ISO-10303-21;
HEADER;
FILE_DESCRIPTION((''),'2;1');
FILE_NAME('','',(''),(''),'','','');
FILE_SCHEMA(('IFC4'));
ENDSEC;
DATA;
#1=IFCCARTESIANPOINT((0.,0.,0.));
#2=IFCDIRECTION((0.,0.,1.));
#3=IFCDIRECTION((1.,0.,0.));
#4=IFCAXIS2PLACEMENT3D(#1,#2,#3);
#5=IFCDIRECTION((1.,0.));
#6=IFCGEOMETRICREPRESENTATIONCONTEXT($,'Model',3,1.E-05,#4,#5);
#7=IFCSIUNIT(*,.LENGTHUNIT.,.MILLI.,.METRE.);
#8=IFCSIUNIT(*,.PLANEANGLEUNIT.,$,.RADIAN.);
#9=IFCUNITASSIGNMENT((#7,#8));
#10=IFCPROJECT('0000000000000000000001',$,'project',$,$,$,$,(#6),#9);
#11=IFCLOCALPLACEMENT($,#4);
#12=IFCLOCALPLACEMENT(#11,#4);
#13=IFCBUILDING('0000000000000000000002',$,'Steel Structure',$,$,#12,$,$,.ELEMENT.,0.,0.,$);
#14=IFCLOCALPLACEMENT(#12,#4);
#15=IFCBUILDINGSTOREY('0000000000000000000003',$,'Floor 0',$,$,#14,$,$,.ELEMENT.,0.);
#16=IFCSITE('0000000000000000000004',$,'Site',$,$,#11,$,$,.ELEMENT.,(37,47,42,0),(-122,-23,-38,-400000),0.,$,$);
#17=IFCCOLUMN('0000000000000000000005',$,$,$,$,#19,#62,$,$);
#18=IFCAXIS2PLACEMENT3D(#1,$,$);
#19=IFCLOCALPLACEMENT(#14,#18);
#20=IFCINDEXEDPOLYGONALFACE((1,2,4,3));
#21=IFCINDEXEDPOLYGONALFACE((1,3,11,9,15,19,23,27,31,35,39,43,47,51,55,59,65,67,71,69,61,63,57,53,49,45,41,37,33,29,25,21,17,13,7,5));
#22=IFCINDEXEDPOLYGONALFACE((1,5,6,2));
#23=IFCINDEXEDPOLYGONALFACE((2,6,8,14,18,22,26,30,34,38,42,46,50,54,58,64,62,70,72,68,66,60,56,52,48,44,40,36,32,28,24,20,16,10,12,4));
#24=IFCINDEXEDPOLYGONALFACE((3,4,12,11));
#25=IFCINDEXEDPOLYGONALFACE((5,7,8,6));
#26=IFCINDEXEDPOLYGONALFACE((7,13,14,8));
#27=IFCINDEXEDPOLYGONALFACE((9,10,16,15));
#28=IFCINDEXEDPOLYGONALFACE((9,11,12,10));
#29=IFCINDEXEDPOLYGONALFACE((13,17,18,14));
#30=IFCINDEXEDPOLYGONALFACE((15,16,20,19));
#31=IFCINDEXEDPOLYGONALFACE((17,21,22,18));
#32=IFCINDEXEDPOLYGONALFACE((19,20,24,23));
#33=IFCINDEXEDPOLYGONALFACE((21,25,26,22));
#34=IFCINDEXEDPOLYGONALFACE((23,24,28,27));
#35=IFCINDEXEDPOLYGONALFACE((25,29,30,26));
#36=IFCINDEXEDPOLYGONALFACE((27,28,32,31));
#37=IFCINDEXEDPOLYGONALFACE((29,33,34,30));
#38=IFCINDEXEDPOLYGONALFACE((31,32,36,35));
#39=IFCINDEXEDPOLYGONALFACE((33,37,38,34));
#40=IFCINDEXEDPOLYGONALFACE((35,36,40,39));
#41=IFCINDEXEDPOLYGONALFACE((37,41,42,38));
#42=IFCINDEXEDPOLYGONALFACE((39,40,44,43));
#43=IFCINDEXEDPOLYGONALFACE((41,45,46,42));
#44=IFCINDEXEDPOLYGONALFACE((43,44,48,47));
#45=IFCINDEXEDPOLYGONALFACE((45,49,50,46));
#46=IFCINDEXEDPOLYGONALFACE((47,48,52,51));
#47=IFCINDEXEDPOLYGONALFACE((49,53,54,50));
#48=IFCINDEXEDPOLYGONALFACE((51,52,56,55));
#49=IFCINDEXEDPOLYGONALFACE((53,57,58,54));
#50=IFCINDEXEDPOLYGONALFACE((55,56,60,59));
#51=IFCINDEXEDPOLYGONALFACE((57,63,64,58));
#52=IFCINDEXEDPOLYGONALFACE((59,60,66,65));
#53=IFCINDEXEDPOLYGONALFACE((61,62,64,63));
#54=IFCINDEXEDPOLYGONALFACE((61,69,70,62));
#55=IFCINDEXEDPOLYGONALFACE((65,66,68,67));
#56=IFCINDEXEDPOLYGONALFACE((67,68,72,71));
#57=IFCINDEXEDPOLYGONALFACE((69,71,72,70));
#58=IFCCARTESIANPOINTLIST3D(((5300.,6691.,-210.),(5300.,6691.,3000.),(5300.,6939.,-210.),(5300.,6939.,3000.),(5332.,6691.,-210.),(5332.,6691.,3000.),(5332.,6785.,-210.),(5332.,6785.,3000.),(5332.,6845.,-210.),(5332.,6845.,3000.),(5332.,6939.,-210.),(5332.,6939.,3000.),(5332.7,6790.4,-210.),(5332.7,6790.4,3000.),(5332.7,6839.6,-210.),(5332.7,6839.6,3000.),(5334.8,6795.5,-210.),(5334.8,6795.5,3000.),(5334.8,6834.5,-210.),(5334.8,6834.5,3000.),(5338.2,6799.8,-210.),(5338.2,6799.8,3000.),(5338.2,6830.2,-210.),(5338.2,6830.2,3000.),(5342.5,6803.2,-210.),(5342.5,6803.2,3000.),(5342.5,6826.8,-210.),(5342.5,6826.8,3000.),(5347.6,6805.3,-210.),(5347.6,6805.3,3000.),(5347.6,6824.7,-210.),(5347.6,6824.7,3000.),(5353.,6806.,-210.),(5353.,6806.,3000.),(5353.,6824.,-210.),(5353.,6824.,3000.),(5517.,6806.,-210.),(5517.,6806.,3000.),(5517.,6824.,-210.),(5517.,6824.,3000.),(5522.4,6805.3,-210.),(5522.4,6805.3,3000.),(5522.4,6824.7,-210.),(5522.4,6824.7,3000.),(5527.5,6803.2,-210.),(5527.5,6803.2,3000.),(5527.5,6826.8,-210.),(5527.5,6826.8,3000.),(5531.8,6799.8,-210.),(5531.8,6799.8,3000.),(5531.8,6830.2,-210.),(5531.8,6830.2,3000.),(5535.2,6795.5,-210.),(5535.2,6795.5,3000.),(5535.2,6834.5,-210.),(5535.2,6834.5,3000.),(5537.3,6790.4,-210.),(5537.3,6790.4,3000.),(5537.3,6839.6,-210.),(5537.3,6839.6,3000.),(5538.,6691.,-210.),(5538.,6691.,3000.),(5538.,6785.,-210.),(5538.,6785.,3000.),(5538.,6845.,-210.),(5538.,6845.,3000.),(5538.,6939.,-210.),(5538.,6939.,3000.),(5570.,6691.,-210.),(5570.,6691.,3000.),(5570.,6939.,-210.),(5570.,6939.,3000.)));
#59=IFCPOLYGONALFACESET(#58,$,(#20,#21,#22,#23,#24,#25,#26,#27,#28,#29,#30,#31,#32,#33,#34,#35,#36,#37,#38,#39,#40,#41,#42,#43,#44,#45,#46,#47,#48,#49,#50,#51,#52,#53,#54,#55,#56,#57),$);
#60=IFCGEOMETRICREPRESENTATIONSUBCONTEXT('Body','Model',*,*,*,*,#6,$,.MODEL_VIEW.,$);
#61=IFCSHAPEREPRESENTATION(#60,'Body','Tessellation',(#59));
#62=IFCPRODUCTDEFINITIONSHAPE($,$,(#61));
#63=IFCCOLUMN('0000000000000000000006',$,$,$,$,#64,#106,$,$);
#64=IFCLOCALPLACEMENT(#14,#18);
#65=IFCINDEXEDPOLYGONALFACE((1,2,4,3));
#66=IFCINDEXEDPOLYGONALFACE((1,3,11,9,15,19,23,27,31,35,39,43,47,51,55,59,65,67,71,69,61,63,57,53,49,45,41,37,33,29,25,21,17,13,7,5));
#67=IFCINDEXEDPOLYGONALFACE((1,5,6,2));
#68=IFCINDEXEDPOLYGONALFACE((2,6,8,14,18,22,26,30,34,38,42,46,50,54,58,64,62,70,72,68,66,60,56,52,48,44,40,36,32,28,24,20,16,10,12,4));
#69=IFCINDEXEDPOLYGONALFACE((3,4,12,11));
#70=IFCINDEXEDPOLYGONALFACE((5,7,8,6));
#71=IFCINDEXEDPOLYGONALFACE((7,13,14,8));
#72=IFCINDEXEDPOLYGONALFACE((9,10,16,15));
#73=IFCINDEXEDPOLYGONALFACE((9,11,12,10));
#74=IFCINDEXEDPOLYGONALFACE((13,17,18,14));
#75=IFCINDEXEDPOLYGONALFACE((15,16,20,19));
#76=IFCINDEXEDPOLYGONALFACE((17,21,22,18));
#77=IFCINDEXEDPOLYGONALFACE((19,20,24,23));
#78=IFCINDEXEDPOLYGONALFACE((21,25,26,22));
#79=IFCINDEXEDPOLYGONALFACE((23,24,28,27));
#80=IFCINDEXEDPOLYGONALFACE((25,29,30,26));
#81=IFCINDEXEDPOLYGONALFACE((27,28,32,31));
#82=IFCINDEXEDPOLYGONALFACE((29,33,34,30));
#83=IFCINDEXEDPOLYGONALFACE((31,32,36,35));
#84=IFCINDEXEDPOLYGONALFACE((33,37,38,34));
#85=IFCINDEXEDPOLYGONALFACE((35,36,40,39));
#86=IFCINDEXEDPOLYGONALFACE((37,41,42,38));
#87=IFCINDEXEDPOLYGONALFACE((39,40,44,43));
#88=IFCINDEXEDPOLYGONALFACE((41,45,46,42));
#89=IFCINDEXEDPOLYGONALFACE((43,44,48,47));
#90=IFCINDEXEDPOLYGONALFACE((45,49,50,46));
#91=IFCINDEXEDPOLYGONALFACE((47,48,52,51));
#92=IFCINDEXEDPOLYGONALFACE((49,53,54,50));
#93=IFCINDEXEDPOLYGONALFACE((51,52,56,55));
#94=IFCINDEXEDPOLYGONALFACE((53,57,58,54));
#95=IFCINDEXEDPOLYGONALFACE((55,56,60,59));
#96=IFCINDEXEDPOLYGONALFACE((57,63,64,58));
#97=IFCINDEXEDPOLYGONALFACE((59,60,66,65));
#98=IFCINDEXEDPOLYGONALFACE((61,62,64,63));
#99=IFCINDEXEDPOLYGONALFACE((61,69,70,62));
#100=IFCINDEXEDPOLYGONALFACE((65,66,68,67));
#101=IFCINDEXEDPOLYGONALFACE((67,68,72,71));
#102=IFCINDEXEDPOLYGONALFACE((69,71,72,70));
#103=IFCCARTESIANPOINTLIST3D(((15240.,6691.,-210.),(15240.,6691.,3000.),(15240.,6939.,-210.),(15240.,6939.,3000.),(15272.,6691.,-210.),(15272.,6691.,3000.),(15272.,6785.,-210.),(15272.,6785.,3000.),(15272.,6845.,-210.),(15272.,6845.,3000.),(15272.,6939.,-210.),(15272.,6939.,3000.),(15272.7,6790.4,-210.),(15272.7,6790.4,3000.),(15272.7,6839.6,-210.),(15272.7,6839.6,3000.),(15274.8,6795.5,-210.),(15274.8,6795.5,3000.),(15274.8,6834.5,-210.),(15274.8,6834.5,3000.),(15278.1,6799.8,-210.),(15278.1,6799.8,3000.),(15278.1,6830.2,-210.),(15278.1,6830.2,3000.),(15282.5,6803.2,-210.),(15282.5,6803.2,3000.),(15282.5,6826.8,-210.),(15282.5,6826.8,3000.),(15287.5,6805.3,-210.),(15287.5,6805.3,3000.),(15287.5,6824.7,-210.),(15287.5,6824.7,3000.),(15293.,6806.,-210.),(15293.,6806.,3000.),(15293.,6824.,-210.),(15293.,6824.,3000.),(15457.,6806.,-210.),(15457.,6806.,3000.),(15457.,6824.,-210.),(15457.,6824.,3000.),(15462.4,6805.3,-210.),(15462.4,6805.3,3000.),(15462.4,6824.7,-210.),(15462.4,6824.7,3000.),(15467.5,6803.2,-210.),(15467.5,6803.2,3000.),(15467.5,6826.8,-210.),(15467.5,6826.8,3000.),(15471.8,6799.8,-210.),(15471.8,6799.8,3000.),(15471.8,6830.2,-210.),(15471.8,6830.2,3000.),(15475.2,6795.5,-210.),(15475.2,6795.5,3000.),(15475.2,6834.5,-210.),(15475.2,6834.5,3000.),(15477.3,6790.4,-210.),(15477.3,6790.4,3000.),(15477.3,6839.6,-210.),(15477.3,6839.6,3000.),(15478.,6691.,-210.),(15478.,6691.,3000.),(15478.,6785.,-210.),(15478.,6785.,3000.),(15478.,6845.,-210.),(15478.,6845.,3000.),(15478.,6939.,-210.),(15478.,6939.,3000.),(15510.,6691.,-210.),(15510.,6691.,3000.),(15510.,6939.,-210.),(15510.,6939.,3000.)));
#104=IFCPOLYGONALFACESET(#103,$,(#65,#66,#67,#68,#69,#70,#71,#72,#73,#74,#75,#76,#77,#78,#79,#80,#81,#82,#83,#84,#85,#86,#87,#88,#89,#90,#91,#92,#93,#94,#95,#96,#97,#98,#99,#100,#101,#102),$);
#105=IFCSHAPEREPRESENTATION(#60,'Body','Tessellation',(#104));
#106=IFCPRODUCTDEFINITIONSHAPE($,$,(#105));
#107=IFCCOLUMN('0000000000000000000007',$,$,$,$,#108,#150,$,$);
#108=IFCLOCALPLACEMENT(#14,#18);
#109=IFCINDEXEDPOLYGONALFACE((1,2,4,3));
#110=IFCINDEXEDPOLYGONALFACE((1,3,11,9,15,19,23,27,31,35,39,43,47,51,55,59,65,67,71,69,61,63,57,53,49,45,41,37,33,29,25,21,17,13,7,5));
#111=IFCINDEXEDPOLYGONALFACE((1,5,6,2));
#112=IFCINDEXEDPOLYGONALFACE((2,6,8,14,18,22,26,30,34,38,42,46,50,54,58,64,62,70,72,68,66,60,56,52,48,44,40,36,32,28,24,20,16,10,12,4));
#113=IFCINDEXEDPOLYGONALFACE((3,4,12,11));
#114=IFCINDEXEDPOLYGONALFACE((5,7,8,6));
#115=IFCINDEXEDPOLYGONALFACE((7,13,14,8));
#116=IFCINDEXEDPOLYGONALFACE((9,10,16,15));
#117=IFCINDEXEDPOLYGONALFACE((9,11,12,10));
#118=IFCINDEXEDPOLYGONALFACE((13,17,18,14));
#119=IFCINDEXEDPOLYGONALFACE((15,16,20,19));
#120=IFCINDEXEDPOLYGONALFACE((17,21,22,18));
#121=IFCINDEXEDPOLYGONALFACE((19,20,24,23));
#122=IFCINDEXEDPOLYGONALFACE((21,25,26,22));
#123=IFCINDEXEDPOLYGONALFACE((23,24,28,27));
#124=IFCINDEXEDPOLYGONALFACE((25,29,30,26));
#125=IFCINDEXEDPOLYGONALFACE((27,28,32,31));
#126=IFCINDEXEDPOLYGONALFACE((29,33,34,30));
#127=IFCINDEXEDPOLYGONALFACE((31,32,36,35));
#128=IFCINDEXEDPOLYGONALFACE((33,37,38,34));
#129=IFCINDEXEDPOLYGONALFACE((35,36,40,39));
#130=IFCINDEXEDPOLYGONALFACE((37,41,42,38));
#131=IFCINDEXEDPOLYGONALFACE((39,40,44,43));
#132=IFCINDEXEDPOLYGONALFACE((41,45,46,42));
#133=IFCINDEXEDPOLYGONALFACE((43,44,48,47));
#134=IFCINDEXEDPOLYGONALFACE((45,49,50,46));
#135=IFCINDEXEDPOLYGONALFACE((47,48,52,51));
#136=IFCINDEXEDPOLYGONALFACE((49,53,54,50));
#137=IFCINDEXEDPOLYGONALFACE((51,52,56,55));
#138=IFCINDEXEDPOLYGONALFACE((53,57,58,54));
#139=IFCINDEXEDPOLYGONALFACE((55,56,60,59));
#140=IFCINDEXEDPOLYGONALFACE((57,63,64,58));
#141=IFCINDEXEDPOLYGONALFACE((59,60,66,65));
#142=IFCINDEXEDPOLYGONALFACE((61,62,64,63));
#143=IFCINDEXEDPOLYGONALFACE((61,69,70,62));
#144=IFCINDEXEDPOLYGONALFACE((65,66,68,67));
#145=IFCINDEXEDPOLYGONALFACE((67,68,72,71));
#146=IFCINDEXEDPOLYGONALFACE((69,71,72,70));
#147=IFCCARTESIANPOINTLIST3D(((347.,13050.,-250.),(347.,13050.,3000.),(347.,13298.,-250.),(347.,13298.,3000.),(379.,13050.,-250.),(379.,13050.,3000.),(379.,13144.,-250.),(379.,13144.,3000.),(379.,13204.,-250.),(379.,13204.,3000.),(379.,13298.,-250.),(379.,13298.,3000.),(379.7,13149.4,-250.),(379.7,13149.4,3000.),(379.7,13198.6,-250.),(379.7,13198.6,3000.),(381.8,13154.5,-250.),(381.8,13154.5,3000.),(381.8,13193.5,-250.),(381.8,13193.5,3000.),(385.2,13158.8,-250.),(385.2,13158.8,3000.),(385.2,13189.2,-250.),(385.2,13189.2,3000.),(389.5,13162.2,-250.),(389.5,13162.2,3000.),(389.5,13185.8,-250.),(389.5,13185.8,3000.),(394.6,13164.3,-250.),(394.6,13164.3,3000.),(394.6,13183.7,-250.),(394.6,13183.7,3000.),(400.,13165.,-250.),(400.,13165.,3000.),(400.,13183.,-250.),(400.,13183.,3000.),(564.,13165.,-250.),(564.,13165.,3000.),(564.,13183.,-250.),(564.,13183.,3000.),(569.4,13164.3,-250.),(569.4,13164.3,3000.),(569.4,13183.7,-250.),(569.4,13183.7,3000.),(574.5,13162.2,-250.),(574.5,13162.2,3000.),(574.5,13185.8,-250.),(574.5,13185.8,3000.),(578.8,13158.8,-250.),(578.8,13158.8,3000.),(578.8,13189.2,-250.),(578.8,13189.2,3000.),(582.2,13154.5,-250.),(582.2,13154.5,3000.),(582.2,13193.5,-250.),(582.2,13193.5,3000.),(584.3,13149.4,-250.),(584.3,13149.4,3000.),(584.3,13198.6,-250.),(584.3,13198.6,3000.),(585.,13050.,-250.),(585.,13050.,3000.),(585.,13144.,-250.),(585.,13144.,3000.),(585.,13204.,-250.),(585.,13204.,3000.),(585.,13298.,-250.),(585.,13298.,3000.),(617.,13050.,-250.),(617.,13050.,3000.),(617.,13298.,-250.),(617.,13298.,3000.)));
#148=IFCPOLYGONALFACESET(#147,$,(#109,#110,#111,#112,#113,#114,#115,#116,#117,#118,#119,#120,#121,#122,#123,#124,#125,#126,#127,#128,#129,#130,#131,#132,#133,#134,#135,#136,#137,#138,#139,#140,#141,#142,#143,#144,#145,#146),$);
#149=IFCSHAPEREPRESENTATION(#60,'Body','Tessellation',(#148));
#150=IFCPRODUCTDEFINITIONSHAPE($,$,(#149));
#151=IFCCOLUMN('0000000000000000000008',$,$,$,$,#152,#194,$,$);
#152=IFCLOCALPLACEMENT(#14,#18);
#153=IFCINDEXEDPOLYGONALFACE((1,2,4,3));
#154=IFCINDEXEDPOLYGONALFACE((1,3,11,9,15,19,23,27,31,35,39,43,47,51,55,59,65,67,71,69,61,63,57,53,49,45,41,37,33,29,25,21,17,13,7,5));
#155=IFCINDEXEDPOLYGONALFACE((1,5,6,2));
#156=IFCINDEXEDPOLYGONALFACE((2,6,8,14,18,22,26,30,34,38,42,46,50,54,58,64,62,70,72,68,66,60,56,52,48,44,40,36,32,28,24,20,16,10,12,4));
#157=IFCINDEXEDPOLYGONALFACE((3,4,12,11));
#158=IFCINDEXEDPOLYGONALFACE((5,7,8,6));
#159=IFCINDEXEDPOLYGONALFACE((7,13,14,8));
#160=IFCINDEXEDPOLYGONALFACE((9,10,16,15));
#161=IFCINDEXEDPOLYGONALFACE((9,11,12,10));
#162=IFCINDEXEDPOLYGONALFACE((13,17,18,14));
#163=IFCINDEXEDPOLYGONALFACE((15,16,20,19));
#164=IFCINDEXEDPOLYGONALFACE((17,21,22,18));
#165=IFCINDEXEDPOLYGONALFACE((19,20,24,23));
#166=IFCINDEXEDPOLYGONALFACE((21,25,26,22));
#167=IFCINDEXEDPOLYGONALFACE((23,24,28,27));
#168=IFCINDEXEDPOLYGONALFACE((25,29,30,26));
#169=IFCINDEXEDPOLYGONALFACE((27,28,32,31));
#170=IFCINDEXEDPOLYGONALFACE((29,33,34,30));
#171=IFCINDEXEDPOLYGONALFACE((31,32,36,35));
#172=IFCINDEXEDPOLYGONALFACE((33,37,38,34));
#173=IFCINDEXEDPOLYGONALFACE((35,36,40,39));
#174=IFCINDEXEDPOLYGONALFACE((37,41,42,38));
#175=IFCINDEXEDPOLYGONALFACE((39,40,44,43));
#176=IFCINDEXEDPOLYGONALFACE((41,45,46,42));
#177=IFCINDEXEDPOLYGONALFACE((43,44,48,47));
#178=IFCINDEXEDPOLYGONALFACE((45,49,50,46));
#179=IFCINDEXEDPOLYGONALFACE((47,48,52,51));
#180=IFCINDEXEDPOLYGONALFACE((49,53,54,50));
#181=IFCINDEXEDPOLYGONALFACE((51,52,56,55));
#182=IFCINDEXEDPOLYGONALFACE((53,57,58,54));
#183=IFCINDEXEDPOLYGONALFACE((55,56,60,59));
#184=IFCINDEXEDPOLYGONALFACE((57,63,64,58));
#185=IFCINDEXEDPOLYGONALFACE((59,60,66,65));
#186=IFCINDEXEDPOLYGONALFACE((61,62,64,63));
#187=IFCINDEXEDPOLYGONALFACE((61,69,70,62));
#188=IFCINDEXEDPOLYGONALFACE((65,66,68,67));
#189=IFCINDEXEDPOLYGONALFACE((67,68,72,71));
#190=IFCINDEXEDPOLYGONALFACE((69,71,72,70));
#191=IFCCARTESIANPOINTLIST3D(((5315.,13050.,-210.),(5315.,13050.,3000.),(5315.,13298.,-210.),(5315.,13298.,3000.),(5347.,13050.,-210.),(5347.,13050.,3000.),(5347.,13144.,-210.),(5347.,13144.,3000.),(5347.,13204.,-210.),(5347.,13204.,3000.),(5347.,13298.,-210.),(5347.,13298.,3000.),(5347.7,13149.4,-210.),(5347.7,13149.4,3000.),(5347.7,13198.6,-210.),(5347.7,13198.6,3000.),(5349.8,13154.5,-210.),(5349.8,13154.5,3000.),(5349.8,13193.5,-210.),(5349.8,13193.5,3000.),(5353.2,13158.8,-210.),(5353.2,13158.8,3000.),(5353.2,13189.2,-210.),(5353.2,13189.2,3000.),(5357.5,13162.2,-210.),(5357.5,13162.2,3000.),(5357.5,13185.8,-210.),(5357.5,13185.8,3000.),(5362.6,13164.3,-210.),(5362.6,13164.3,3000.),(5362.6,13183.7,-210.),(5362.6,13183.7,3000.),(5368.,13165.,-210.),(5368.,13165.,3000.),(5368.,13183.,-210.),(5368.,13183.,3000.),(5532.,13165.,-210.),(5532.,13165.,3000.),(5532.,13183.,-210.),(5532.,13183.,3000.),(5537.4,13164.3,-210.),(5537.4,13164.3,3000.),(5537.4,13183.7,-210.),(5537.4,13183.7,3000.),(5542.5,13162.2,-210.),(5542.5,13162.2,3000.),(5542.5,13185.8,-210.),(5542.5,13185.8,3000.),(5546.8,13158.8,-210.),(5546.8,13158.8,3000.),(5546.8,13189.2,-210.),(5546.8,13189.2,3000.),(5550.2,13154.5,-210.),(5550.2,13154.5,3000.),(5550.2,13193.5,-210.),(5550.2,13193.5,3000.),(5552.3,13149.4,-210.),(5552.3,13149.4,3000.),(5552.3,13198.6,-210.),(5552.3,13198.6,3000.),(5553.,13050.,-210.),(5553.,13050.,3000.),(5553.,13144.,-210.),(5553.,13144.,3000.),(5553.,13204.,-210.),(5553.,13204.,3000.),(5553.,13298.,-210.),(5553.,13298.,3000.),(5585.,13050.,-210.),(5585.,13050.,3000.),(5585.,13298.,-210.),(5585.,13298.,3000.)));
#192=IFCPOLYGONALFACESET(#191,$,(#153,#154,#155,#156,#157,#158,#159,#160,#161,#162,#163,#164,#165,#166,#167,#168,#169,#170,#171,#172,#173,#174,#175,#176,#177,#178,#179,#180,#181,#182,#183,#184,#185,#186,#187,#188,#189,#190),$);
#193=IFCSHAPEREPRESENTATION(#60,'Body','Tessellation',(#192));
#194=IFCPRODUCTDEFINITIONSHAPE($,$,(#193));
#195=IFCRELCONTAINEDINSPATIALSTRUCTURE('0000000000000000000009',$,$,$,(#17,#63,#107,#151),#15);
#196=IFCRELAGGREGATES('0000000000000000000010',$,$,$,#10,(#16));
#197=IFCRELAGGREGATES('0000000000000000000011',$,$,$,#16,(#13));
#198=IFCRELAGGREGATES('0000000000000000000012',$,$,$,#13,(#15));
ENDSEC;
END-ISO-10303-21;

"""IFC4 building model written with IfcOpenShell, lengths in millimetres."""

from ifc_helpers import new_model, si_unit, direction, frame, origin_with_axes, origin_2d_with_axis, place, context, subcontext, project, spatial, i_section, extrude, element, save


model = new_model("IFC4")

# Units and contexts
model_context = context("Model", 3, precision=1e-05, world=origin_with_axes(), true_north=direction((1.0, 0.0)))
body_context = subcontext(model_context, "Body", "Model", "MODEL_VIEW")
ifc_project = project(units=[si_unit("LENGTHUNIT", "METRE", prefix="MILLI"), si_unit("PLANEANGLEUNIT", "RADIAN")], contexts=[model_context])

# Site, building, storey
site_placement = place(None, origin_with_axes())
site = spatial("IfcSite", under=ifc_project, at=site_placement, Name="Site", CompositionType="ELEMENT", RefLatitude=(37, 47, 42, 0), RefLongitude=(-122, -23, -38, -400000), RefElevation=0.0)
building_placement = place(site_placement, origin_with_axes())
building = spatial("IfcBuilding", under=site, at=building_placement, Name="Steel Structure", CompositionType="ELEMENT", ElevationOfRefHeight=0.0, ElevationOfTerrain=0.0)
storey_placement = place(building_placement, origin_with_axes())
storey = spatial("IfcBuildingStorey", under=building, at=storey_placement, Name="Floor 0", CompositionType="ELEMENT", Elevation=0.0)

# Columns
for number, where, z_axis, x_axis in (
    (1, (5435.0, 6815.0, -210.0), (0.0, 0.0, 1.0), (0.0, -1.0, 0.0)),
    (2, (15375.0, 6815.0, -210.0), (0.0, 0.0, 1.0), (0.0, -1.0, 0.0)),
):
    element("IfcColumn", number, at=place(storey_placement, frame(where, z_axis=z_axis, x_axis=x_axis)), inside=storey, context=body_context, shape_type="SweptSolid", body=[
        extrude(i_section(OverallWidth=248.0, OverallDepth=270.0, WebThickness=18.0, FlangeThickness=32.0, FilletRadius=21.0, at=origin_2d_with_axis()), origin_with_axes(), (0.0, 0.0, 1.0), 3210.0),
    ])
column_1_placement = place(storey_placement, frame((482.0, 13174.0, -250.0), z_axis=(0.0, 0.0, 1.0), x_axis=(0.0, -1.0, 0.0)))
element("IfcColumn", 3, at=column_1_placement, inside=storey, context=body_context, shape_type="SweptSolid", body=[
    extrude(i_section(OverallWidth=248.0, OverallDepth=270.0, WebThickness=18.0, FlangeThickness=32.0, FilletRadius=21.0, at=origin_2d_with_axis()), origin_with_axes(), (0.0, 0.0, 1.0), 3250.0),
])
column_2_placement = place(storey_placement, frame((5450.0, 13174.0, -210.0), z_axis=(0.0, 0.0, 1.0), x_axis=(0.0, -1.0, 0.0)))
element("IfcColumn", 4, at=column_2_placement, inside=storey, context=body_context, shape_type="SweptSolid", body=[
    extrude(i_section(OverallWidth=248.0, OverallDepth=270.0, WebThickness=18.0, FlangeThickness=32.0, FilletRadius=21.0, at=origin_2d_with_axis()), origin_with_axes(), (0.0, 0.0, 1.0), 3210.0),
])

save(model, "model.ifc")
